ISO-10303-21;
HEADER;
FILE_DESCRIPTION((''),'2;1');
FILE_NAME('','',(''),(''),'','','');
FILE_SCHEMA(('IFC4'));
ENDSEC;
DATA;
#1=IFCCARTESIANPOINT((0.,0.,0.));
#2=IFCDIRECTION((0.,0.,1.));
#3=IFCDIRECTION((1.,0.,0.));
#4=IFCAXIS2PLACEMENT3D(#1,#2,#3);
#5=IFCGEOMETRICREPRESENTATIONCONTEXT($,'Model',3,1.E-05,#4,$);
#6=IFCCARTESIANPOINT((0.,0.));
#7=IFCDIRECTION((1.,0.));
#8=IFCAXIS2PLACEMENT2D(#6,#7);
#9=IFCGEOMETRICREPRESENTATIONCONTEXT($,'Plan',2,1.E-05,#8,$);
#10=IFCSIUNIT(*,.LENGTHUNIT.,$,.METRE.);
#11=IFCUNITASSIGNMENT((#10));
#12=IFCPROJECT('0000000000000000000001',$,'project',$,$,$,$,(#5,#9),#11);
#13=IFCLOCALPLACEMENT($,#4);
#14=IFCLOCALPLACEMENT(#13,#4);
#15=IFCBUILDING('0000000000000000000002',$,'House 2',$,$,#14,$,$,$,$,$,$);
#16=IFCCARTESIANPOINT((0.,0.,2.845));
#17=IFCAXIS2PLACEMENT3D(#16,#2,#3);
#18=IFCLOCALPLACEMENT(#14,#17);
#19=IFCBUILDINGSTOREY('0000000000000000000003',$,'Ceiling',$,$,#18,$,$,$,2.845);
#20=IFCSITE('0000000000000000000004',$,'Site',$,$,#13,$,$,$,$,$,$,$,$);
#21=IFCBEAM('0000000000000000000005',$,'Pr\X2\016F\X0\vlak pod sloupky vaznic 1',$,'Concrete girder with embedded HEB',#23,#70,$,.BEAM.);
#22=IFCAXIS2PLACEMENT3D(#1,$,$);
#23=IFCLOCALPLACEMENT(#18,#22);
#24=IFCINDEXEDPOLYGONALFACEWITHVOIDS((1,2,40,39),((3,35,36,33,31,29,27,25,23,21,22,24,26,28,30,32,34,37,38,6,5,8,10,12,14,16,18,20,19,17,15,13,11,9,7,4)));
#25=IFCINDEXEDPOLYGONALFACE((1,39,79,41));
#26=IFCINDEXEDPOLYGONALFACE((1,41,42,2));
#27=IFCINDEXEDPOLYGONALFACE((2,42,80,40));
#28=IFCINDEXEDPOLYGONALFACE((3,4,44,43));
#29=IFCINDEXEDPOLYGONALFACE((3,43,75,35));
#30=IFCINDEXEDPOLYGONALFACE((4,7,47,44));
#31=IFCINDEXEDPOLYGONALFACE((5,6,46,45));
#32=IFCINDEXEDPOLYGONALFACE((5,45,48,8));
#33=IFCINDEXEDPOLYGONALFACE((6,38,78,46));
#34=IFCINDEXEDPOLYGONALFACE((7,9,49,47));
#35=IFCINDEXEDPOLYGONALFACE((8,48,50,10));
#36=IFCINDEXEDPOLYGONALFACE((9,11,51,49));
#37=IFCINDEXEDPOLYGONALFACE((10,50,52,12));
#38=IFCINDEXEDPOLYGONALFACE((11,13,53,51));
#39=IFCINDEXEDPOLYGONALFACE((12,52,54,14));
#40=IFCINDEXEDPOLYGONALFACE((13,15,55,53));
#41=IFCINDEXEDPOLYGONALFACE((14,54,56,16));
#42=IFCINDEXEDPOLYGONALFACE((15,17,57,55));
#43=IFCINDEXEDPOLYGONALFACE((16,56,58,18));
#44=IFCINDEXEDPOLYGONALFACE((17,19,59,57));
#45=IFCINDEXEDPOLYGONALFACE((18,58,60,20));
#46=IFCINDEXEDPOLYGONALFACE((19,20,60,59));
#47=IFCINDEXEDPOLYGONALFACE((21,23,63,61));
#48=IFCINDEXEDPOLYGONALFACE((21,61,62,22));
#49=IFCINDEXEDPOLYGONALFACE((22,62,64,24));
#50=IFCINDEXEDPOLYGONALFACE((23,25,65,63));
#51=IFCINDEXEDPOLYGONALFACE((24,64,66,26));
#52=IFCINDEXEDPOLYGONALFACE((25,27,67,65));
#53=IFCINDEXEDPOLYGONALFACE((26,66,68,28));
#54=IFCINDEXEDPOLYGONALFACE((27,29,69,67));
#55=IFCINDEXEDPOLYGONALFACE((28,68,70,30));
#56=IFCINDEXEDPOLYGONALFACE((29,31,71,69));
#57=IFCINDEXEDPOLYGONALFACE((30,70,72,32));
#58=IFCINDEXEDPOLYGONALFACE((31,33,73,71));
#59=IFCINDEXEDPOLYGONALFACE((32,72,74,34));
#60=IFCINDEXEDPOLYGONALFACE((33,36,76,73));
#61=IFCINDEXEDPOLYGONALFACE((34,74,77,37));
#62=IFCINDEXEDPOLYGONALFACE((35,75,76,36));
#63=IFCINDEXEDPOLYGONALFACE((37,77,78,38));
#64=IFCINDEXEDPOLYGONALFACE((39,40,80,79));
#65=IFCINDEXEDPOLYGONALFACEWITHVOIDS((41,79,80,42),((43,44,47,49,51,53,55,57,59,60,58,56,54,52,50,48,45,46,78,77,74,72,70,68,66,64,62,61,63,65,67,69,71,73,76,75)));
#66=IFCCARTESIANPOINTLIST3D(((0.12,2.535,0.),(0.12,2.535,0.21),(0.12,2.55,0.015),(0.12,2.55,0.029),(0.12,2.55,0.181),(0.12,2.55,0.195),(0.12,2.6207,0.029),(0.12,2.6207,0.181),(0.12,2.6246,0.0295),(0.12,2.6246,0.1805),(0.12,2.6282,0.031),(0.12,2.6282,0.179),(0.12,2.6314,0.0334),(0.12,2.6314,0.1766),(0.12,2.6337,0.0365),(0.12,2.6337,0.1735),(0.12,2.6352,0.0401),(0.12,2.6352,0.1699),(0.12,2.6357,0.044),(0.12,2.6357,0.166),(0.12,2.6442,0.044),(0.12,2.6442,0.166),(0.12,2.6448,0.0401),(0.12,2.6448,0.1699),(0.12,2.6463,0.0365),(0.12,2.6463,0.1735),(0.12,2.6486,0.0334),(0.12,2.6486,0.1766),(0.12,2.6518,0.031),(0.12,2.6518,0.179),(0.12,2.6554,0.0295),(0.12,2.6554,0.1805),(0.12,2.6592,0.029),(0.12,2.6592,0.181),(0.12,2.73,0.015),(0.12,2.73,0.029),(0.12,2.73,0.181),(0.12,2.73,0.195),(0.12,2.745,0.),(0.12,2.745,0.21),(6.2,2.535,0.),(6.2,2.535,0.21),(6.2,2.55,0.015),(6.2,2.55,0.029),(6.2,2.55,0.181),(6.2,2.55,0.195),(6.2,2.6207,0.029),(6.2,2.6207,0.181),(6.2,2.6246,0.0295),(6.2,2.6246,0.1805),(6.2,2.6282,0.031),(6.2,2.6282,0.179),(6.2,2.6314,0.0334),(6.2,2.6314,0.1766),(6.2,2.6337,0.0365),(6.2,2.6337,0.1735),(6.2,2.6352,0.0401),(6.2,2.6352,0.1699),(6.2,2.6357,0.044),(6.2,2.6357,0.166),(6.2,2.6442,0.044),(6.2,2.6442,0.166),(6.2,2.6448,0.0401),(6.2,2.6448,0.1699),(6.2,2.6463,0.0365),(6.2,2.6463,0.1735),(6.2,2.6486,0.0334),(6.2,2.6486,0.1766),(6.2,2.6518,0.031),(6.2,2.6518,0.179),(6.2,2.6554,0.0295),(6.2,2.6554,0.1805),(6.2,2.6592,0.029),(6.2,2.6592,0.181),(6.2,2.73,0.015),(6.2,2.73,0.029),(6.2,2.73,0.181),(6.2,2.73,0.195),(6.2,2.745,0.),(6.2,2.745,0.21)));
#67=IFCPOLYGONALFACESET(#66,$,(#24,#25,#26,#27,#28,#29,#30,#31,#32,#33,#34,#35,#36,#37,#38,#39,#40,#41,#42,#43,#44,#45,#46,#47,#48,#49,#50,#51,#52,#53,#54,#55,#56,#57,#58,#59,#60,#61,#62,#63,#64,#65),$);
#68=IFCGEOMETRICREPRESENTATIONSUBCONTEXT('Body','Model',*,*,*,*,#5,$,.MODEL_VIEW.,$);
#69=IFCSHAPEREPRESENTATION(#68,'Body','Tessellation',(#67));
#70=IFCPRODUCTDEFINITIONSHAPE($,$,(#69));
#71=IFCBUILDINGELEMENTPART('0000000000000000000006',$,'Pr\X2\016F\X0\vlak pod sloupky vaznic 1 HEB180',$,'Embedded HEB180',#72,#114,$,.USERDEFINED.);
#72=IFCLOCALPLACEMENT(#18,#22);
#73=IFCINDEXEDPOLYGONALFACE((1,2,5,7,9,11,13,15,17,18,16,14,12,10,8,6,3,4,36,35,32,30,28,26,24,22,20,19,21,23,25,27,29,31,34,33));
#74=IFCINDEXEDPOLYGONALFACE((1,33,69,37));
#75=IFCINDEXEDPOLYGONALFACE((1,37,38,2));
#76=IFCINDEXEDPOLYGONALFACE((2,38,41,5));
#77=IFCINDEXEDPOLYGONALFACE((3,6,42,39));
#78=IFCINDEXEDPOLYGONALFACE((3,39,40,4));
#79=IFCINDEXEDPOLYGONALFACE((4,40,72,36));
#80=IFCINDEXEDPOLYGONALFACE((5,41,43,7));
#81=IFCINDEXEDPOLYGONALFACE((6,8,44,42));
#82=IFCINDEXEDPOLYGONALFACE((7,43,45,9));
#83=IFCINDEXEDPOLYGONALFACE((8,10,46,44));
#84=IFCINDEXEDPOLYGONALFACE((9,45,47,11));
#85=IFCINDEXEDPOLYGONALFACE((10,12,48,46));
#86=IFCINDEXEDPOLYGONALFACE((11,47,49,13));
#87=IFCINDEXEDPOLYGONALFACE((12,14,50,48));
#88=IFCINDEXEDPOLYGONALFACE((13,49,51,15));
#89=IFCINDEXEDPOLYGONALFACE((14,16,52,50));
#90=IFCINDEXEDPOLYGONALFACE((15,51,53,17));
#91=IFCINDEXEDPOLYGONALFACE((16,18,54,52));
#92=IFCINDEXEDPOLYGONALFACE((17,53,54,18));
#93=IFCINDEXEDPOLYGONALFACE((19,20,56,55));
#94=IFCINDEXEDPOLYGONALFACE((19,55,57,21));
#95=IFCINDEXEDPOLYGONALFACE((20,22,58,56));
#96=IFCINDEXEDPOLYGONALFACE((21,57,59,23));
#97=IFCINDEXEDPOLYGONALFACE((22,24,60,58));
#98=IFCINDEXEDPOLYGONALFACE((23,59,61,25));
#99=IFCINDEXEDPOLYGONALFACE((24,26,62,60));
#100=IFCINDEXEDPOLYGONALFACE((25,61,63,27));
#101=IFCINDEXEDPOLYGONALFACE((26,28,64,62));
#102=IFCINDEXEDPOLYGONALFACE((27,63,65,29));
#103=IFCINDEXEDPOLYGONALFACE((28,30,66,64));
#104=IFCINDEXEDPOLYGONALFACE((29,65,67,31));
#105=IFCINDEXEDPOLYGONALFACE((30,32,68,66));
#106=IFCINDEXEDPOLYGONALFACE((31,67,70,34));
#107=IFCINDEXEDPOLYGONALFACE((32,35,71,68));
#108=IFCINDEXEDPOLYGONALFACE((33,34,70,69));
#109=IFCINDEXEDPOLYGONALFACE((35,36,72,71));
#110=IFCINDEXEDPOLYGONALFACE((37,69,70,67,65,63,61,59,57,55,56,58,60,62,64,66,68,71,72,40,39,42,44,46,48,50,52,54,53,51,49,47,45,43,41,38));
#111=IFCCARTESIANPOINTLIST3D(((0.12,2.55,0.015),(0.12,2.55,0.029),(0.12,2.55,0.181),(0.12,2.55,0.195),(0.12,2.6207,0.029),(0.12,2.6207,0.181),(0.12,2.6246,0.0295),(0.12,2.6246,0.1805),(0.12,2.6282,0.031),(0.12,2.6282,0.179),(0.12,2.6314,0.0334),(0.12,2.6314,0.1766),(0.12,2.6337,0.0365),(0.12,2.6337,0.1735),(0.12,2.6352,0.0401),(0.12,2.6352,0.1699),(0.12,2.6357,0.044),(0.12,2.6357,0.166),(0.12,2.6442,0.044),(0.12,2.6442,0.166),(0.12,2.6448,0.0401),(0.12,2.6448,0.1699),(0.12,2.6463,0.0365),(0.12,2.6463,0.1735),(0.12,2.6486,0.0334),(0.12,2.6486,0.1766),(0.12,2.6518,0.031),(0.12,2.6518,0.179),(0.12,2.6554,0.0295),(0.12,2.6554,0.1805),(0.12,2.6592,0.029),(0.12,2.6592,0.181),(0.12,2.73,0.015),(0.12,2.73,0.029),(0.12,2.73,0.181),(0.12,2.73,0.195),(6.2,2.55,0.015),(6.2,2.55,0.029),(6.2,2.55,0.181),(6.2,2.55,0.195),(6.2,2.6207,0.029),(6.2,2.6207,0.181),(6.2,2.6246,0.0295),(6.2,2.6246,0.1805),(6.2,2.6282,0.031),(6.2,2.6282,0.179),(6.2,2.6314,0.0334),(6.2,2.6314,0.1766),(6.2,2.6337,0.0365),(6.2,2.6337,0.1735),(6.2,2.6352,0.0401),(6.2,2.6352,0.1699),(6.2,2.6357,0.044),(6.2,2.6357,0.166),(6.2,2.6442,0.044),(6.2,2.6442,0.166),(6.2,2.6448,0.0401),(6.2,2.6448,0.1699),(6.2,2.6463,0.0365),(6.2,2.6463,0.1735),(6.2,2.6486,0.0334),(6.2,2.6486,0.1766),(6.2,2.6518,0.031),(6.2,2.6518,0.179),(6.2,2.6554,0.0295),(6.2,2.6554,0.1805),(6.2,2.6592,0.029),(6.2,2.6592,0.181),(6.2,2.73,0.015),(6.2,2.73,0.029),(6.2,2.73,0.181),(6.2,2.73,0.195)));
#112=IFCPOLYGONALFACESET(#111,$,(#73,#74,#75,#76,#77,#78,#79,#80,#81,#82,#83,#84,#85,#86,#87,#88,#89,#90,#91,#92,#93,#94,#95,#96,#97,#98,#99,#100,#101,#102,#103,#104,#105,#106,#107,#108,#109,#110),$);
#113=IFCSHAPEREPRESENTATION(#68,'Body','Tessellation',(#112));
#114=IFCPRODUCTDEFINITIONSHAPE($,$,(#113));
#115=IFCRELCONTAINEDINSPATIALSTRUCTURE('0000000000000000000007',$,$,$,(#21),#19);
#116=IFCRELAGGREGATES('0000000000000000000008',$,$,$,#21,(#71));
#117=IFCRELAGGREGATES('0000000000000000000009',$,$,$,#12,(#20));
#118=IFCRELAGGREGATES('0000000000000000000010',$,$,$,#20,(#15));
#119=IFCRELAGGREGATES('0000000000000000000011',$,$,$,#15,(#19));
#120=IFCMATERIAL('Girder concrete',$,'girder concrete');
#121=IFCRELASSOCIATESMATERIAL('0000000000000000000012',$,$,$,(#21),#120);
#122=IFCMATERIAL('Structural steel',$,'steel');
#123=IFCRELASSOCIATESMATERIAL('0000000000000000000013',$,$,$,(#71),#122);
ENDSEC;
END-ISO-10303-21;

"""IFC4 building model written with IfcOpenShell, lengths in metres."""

from ifc_helpers import new_model, si_unit, frame, origin_with_axes, origin_2d_with_axis, place, context, subcontext, project, spatial, rectangle, i_section, extrude, boolean, material, element, aggregate, save


model = new_model("IFC4")

# Units and contexts
model_context = context("Model", 3, precision=1e-05, world=origin_with_axes())
plan_context = context("Plan", 2, precision=1e-05, world=origin_2d_with_axis())
body_context = subcontext(model_context, "Body", "Model", "MODEL_VIEW")
ifc_project = project(units=[si_unit("LENGTHUNIT", "METRE")], contexts=[model_context, plan_context])

# Site, building, storey
site_placement = place(None, origin_with_axes())
site = spatial("IfcSite", under=ifc_project, at=site_placement, Name="Site")
building_placement = place(site_placement, origin_with_axes())
building = spatial("IfcBuilding", under=site, at=building_placement, Name="House 2")
storey_placement = place(building_placement, frame((0.0, 0.0, 2.845), z_axis=(0.0, 0.0, 1.0), x_axis=(1.0, 0.0, 0.0)))
storey = spatial("IfcBuildingStorey", under=building, at=storey_placement, Name="Ceiling", Elevation=2.845)

# Beam
ifc_material_1 = material(Name="Girder concrete", Category="girder concrete")
beam_1_placement = place(storey_placement, frame((0.12, 2.64, 0.105), z_axis=(0.0, 0.0, 1.0), x_axis=(1.0, 0.0, 0.0)))
beam_1 = element("IfcBeam", 1, at=beam_1_placement, inside=storey, material=ifc_material_1, Name="Průvlak pod sloupky vaznic 1", ObjectType="Concrete girder with embedded HEB", PredefinedType="BEAM", context=body_context, shape_type="CSG", body=[
    boolean("DIFFERENCE", extrude(rectangle(XDim=0.21, YDim=0.21), frame((0.0, 0.0, 0.0), z_axis=(1.0, 0.0, 0.0), x_axis=(0.0, 1.0, 0.0)), (0.0, 0.0, 1.0), 6.08), extrude(i_section(OverallWidth=0.18, OverallDepth=0.18, WebThickness=0.0085, FlangeThickness=0.014, FilletRadius=0.015), frame((0.0, 0.0, 0.0), z_axis=(1.0, 0.0, 0.0), x_axis=(0.0, 1.0, 0.0)), (0.0, 0.0, 1.0), 6.08)),
])

# Building element part
ifc_material_2 = material(Name="Structural steel", Category="steel")
building_element_part_placement = place(beam_1_placement, origin_with_axes())
building_element_part = element("IfcBuildingElementPart", 2, at=building_element_part_placement, material=ifc_material_2, Name="Průvlak pod sloupky vaznic 1 HEB180", ObjectType="Embedded HEB180", PredefinedType="USERDEFINED", context=body_context, shape_type="SweptSolid", body=[
    extrude(i_section(OverallWidth=0.18, OverallDepth=0.18, WebThickness=0.0085, FlangeThickness=0.014, FilletRadius=0.015), frame((0.0, 0.0, 0.0), z_axis=(1.0, 0.0, 0.0), x_axis=(0.0, 1.0, 0.0)), (0.0, 0.0, 1.0), 6.08),
])
aggregate(beam_1, [building_element_part])

save(model, "model.ifc")
